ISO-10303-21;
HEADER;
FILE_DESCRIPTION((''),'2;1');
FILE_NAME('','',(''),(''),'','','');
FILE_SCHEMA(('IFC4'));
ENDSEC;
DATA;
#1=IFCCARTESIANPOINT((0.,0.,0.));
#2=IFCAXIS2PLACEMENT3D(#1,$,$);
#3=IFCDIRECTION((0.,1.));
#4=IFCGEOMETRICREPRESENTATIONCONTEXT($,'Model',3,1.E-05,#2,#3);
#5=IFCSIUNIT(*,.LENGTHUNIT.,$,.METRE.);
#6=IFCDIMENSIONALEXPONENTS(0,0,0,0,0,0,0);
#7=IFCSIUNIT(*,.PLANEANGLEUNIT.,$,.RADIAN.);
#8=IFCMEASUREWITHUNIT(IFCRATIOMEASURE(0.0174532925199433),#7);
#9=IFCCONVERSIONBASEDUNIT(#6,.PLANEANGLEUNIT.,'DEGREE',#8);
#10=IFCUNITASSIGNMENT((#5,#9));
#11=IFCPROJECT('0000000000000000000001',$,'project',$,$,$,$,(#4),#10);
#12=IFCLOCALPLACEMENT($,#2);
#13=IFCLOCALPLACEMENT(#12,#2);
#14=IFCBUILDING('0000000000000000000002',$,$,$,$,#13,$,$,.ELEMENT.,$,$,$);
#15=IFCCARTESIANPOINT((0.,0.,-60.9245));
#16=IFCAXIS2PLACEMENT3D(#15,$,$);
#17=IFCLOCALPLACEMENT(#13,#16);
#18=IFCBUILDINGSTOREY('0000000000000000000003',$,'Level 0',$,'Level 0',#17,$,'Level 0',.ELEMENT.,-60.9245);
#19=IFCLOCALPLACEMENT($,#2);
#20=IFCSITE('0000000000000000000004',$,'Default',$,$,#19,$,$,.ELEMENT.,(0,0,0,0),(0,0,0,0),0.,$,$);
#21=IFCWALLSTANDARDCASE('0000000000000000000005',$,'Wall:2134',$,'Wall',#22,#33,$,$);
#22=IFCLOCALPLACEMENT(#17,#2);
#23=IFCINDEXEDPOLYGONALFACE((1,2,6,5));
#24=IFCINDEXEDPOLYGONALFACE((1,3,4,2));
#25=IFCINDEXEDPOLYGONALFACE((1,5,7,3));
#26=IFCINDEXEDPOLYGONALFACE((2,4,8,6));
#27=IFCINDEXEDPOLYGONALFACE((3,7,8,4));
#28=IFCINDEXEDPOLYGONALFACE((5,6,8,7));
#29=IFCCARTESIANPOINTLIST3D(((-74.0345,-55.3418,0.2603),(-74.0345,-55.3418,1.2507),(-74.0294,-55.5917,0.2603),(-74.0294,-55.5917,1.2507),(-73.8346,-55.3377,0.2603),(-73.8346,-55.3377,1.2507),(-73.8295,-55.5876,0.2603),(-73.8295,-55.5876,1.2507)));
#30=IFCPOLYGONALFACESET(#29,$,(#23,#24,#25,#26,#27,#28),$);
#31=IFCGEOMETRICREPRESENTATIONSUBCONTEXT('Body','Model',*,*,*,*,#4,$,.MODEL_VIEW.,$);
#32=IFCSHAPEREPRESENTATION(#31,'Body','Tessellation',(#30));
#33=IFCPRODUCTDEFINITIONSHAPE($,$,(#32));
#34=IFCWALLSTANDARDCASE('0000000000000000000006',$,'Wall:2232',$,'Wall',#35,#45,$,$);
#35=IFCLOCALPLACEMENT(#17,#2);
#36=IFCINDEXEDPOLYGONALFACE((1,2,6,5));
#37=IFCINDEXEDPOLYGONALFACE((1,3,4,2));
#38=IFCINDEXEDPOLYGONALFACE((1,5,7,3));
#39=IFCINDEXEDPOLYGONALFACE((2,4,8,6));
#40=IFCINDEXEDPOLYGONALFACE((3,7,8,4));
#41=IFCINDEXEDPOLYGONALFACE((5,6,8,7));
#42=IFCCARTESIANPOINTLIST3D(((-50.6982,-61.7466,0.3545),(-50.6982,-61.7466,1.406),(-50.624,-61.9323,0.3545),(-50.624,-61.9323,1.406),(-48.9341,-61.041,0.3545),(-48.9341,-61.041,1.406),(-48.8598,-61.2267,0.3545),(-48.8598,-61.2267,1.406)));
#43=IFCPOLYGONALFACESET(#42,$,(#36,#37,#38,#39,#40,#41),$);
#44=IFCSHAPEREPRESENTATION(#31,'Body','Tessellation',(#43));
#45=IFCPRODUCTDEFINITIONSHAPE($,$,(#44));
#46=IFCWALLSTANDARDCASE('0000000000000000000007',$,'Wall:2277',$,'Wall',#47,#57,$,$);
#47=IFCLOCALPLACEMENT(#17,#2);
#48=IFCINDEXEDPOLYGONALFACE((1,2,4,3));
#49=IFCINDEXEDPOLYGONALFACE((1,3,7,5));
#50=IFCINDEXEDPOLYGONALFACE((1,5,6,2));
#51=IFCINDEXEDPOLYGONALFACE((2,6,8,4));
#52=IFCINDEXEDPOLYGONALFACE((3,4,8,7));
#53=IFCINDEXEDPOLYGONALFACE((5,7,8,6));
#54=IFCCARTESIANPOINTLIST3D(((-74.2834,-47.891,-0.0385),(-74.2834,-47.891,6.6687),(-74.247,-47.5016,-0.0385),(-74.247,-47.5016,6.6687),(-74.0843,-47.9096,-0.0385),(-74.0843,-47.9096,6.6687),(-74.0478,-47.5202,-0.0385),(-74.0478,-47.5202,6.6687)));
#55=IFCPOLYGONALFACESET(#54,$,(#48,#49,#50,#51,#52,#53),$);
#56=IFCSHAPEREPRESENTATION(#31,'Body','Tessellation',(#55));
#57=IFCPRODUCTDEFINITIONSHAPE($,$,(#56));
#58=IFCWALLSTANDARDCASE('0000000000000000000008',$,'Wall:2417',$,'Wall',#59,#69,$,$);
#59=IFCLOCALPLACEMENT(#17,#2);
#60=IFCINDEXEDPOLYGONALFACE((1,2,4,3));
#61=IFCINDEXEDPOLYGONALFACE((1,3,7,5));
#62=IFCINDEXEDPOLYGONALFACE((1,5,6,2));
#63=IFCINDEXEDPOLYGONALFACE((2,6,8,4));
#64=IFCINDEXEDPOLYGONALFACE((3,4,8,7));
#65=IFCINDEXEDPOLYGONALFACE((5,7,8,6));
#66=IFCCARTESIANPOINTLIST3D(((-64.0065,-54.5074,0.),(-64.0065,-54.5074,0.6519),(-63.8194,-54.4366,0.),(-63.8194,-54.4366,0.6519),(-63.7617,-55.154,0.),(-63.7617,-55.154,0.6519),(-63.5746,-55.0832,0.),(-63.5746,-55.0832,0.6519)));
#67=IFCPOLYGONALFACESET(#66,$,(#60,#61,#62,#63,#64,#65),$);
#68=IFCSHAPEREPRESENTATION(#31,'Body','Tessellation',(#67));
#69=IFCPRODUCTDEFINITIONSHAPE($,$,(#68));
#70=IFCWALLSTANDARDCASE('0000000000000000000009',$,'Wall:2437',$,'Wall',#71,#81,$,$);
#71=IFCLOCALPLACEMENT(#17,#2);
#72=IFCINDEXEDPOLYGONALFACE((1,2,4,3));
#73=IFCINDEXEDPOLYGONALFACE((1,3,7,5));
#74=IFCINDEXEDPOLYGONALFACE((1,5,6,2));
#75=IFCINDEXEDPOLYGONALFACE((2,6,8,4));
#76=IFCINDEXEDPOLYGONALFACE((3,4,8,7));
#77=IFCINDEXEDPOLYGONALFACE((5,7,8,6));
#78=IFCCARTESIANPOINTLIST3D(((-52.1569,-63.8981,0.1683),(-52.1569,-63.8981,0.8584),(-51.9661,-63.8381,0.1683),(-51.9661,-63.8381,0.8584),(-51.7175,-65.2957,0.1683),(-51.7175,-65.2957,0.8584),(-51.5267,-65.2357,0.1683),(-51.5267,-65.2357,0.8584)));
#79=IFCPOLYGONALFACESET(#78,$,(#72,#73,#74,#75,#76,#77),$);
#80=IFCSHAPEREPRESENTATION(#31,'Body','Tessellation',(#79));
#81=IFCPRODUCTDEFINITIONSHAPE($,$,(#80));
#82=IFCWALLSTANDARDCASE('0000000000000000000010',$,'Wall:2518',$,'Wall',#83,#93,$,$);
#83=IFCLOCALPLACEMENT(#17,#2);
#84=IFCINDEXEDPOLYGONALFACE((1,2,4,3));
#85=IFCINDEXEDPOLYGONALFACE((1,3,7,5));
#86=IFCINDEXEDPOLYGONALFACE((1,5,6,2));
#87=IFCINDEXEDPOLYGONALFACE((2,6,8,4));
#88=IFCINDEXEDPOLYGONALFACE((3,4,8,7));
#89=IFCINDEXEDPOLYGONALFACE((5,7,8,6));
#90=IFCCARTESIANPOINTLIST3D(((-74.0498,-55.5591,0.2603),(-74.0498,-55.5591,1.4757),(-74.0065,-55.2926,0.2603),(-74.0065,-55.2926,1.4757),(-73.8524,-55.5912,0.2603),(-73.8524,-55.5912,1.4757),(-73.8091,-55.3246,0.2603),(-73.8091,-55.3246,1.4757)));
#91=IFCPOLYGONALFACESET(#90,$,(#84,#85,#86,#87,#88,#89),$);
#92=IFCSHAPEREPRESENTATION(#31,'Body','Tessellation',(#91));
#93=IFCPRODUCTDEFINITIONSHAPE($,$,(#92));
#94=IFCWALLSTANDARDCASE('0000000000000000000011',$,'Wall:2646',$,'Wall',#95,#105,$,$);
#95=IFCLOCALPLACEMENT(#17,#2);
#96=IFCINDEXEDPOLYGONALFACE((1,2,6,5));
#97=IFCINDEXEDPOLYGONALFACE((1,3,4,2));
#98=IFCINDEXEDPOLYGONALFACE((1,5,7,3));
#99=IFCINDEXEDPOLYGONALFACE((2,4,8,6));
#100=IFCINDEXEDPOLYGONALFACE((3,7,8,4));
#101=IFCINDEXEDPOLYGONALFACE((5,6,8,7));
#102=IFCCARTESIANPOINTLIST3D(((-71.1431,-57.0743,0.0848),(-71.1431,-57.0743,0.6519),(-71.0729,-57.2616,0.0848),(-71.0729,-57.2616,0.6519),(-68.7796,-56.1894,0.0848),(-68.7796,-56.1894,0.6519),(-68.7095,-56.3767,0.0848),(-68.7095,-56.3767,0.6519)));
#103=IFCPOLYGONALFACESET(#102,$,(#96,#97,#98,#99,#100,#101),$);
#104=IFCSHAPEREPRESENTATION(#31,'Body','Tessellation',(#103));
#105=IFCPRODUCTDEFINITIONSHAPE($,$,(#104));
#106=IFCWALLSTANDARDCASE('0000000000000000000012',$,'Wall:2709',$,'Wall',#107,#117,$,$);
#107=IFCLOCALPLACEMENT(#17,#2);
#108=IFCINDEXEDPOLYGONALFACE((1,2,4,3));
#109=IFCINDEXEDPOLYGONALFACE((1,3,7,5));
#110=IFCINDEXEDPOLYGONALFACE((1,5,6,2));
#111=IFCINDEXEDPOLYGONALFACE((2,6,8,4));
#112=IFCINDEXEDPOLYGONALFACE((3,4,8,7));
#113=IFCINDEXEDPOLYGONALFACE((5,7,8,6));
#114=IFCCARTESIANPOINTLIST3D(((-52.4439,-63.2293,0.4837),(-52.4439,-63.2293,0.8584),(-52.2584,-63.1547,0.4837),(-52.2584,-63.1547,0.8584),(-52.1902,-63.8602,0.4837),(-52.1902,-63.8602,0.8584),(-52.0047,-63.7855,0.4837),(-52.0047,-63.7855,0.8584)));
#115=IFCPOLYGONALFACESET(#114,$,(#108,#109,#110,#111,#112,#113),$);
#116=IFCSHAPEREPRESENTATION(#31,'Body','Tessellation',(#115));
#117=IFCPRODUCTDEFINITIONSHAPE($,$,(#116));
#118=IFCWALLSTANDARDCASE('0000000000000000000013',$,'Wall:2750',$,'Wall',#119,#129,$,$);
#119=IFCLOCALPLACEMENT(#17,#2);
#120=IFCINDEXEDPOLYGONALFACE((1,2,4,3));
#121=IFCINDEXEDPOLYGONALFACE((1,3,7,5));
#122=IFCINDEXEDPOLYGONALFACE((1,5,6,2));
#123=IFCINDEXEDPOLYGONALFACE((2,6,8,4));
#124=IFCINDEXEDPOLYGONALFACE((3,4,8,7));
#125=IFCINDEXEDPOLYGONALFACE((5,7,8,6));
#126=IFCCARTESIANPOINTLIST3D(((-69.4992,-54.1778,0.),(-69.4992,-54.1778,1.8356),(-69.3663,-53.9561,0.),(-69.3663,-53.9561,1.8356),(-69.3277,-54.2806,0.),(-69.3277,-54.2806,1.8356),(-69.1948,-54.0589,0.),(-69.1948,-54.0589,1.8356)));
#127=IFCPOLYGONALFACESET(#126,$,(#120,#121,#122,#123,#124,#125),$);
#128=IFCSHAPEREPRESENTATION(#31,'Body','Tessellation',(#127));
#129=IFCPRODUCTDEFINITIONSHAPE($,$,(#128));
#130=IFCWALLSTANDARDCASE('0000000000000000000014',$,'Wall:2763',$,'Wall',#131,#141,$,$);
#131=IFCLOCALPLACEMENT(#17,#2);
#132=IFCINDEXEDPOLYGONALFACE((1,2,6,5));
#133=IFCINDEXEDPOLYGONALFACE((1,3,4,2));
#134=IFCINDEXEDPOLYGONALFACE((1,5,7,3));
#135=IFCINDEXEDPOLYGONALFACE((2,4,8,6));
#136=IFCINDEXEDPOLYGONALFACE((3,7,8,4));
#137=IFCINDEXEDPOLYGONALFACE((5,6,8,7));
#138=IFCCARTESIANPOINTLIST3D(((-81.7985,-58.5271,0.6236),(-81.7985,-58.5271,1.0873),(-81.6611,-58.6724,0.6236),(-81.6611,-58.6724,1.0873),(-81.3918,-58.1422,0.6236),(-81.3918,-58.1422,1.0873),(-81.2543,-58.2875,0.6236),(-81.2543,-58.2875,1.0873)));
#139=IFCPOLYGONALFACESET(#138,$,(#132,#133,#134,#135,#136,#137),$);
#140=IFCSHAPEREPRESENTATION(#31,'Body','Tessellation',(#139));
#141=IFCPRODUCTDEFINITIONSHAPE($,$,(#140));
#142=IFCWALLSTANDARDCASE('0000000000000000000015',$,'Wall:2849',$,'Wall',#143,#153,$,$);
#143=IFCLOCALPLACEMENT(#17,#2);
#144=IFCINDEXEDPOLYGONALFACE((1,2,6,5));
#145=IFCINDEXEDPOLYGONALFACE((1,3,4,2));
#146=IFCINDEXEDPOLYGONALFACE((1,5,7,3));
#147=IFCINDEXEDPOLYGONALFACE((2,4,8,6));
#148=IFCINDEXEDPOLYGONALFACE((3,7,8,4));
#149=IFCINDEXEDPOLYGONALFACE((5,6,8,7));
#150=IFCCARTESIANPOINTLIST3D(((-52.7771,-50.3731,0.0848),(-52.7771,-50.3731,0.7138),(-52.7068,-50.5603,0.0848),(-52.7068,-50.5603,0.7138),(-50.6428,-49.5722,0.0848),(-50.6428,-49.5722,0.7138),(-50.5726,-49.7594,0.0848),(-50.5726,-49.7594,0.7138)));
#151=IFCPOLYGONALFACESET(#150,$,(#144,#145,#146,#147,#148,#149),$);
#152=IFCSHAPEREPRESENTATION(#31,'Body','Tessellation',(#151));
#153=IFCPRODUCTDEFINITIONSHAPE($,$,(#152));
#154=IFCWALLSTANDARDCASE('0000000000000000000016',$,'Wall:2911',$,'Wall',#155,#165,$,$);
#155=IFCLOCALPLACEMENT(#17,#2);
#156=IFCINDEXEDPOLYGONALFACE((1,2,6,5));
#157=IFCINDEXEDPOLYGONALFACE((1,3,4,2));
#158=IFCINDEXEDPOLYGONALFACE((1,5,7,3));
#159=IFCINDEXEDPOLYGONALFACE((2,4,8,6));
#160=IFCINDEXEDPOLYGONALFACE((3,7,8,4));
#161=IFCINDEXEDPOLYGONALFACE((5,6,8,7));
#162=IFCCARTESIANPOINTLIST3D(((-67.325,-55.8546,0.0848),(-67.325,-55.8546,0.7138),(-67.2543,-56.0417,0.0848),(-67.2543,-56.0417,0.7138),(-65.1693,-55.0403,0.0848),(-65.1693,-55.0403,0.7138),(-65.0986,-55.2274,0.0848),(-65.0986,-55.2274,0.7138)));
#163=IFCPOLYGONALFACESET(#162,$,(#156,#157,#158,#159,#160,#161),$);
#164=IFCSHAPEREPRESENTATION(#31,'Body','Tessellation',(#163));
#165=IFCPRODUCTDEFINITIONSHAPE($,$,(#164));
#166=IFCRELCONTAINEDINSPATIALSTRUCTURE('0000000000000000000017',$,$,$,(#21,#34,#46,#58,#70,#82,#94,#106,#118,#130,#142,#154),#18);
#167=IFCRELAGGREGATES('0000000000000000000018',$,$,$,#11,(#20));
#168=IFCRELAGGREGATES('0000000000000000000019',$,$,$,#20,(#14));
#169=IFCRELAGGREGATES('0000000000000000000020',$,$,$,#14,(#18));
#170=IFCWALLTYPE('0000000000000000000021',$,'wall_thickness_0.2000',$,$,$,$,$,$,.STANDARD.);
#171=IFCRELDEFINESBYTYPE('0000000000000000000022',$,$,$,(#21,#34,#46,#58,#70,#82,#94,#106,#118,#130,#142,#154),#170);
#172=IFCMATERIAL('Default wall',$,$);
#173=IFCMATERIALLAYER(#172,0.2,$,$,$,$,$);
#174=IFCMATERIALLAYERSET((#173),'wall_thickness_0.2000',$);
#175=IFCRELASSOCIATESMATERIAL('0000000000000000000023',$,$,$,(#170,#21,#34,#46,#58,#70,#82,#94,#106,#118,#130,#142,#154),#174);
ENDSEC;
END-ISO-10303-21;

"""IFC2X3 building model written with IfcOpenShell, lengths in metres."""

from ifc_helpers import new_model, entity, si_unit, converted_unit, direction, frame, origin, place, context, subcontext, project, spatial, polyline, outline, extrude, material, layer, layer_set, layer_usage, type_object, element, save


model = new_model("IFC2X3")

# Units and contexts
model_context = context("Model", 3, precision=1e-05, world=origin(), true_north=direction((0.0, 1.0)))
body_context = subcontext(model_context, "Body", "Model", "MODEL_VIEW")
ifc_project = project(units=[si_unit("LENGTHUNIT", "METRE"), converted_unit("PLANEANGLEUNIT", "DEGREE", entity("IfcRatioMeasure", 0.0174532925199433), si_unit("PLANEANGLEUNIT", "RADIAN"), dimensions=[0, 0, 0, 0, 0, 0, 0])], contexts=[model_context])

# Site, building, storey
site_placement = place(None, origin())
site = spatial("IfcSite", under=ifc_project, at=site_placement, Name="Default", CompositionType="ELEMENT", RefLatitude=(0, 0, 0, 0), RefLongitude=(0, 0, 0, 0), RefElevation=0.0)
placement_1 = place(None, origin())
building_placement = place(placement_1, origin())
building = spatial("IfcBuilding", under=site, at=building_placement, CompositionType="ELEMENT")
storey_placement = place(building_placement, frame((0.0, 0.0, -60.9245)))
storey = spatial("IfcBuildingStorey", under=building, at=storey_placement, Name="Level 0", ObjectType="Level 0", LongName="Level 0", CompositionType="ELEMENT", Elevation=-60.9245)

# Walls
ifc_material = material(Name="Default wall")
ifc_layer = layer(ifc_material, 0.2)
ifc_layer_set = layer_set([ifc_layer], Name="wall_thickness_0.2000")
ifc_layer_usage = layer_usage(ifc_layer_set, "AXIS2", "POSITIVE", -0.1)
wall_type = type_object("IfcWallType", Name="wall_thickness_0.2000", PredefinedType="STANDARD", material=ifc_layer_set)
placement_2 = place(building_placement, frame((0.0, 0.0, -60.6642)))
wall_1_placement = place(placement_2, frame((-73.9346, -55.3397, 0.0), z_axis=(0.0, 0.0, 1.0), x_axis=(0.020477, -0.99979, 0.0)))
element("IfcWallStandardCase", 1, at=wall_1_placement, inside=storey, type_object=wall_type, material=ifc_layer_usage, Name="Wall:2134", ObjectType="Wall", context=body_context, shape_type="SweptSolid", body=[
    extrude(outline(polyline([(0.25, -0.1), (0.25, 0.1), (0.0, 0.1), (0.0, -0.1), (0.25, -0.1)])), origin(), (0.0, 0.0, 1.0), 0.9904),
])
placement_3 = place(building_placement, frame((0.0, 0.0, -60.57)))
wall_2_placement = place(placement_3, frame((-50.6611, -61.8395, 0.0), z_axis=(0.0, 0.0, 1.0), x_axis=(0.928483, 0.371375, 0.0)))
element("IfcWallStandardCase", 2, at=wall_2_placement, inside=storey, type_object=wall_type, material=ifc_layer_usage, Name="Wall:2232", ObjectType="Wall", context=body_context, shape_type="SweptSolid", body=[
    extrude(outline(polyline([(1.9, -0.1), (1.9, 0.1), (0.0, 0.1), (0.0, -0.1), (1.9, -0.1)])), origin(), (0.0, 0.0, 1.0), 1.0515),
])
placement_4 = place(building_placement, frame((0.0, 0.0, -60.963)))
wall_3_placement = place(placement_4, frame((-74.1838, -47.9003, 0.0), z_axis=(0.0, 0.0, 1.0), x_axis=(0.093128, 0.995654, 0.0)))
element("IfcWallStandardCase", 3, at=wall_3_placement, inside=storey, type_object=wall_type, material=ifc_layer_usage, Name="Wall:2277", ObjectType="Wall", context=body_context, shape_type="SweptSolid", body=[
    extrude(outline(polyline([(0.3911, -0.1), (0.3911, 0.1), (0.0, 0.1), (0.0, -0.1), (0.3911, -0.1)])), origin(), (0.0, 0.0, 1.0), 6.7072),
])
wall_4_placement = place(storey_placement, frame((-63.6682, -55.1186, 0.0), z_axis=(0.0, 0.0, 1.0), x_axis=(-0.354021, 0.935238, 0.0)))
element("IfcWallStandardCase", 4, at=wall_4_placement, inside=storey, type_object=wall_type, material=ifc_layer_usage, Name="Wall:2417", ObjectType="Wall", context=body_context, shape_type="SweptSolid", body=[
    extrude(outline(polyline([(0.6914, -0.1), (0.6914, 0.1), (0.0, 0.1), (0.0, -0.1), (0.6914, -0.1)])), origin(), (0.0, 0.0, 1.0), 0.6519),
])
placement_5 = place(building_placement, frame((0.0, 0.0, -60.7562)))
wall_5_placement = place(placement_5, frame((-52.0615, -63.8681, 0.0), z_axis=(0.0, 0.0, 1.0), x_axis=(0.299903, -0.95397, 0.0)))
element("IfcWallStandardCase", 5, at=wall_5_placement, inside=storey, type_object=wall_type, material=ifc_layer_usage, Name="Wall:2437", ObjectType="Wall", context=body_context, shape_type="SweptSolid", body=[
    extrude(outline(polyline([(1.465, -0.1), (1.465, 0.1), (0.0, 0.1), (0.0, -0.1), (1.465, -0.1)])), origin(), (0.0, 0.0, 1.0), 0.69),
])
placement_6 = place(building_placement, frame((0.0, 0.0, -60.6642)))
wall_6_placement = place(placement_6, frame((-73.9078, -55.3086, 0.0), z_axis=(0.0, 0.0, 1.0), x_axis=(-0.160329, -0.987064, 0.0)))
element("IfcWallStandardCase", 6, at=wall_6_placement, inside=storey, type_object=wall_type, material=ifc_layer_usage, Name="Wall:2518", ObjectType="Wall", context=body_context, shape_type="SweptSolid", body=[
    extrude(outline(polyline([(0.27, -0.1), (0.27, 0.1), (0.0, 0.1), (0.0, -0.1), (0.27, -0.1)])), origin(), (0.0, 0.0, 1.0), 1.2154),
])
placement_7 = place(building_placement, frame((0.0, 0.0, -60.8397)))
wall_7_placement = place(placement_7, frame((-71.108, -57.1679, 0.0), z_axis=(0.0, 0.0, 1.0), x_axis=(0.936523, 0.350606, 0.0)))
element("IfcWallStandardCase", 7, at=wall_7_placement, inside=storey, type_object=wall_type, material=ifc_layer_usage, Name="Wall:2646", ObjectType="Wall", context=body_context, shape_type="SweptSolid", body=[
    extrude(outline(polyline([(2.5237, -0.1), (2.5237, 0.1), (0.0, 0.1), (0.0, -0.1), (2.5237, -0.1)])), origin(), (0.0, 0.0, 1.0), 0.5671),
])
placement_8 = place(building_placement, frame((0.0, 0.0, -60.4408)))
wall_8_placement = place(placement_8, frame((-52.3512, -63.192, 0.0), z_axis=(0.0, 0.0, 1.0), x_axis=(0.373112, -0.927786, 0.0)))
element("IfcWallStandardCase", 8, at=wall_8_placement, inside=storey, type_object=wall_type, material=ifc_layer_usage, Name="Wall:2709", ObjectType="Wall", context=body_context, shape_type="SweptSolid", body=[
    extrude(outline(polyline([(0.68, -0.1), (0.68, 0.1), (0.0, 0.1), (0.0, -0.1), (0.68, -0.1)])), origin(), (0.0, 0.0, 1.0), 0.3746),
])
wall_9_placement = place(storey_placement, frame((-69.2805, -54.0075, 0.0), z_axis=(0.0, 0.0, 1.0), x_axis=(-0.514142, -0.857705, 0.0)))
element("IfcWallStandardCase", 9, at=wall_9_placement, inside=storey, type_object=wall_type, material=ifc_layer_usage, Name="Wall:2750", ObjectType="Wall", context=body_context, shape_type="SweptSolid", body=[
    extrude(outline(polyline([(0.2585, -0.1), (0.2585, 0.1), (0.0, 0.1), (0.0, -0.1), (0.2585, -0.1)])), origin(), (0.0, 0.0, 1.0), 1.8356),
])
placement_9 = place(building_placement, frame((0.0, 0.0, -60.3009)))
wall_10_placement = place(placement_9, frame((-81.7298, -58.5998, 0.0), z_axis=(0.0, 0.0, 1.0), x_axis=(0.726387, 0.687286, 0.0)))
element("IfcWallStandardCase", 10, at=wall_10_placement, inside=storey, type_object=wall_type, material=ifc_layer_usage, Name="Wall:2763", ObjectType="Wall", context=body_context, shape_type="SweptSolid", body=[
    extrude(outline(polyline([(0.56, -0.1), (0.56, 0.1), (0.0, 0.1), (0.0, -0.1), (0.56, -0.1)])), origin(), (0.0, 0.0, 1.0), 0.4637),
])
placement_10 = place(building_placement, frame((0.0, 0.0, -60.8397)))
wall_11_placement = place(placement_10, frame((-52.7419, -50.4667, 0.0), z_axis=(0.0, 0.0, 1.0), x_axis=(0.936246, 0.351346, 0.0)))
element("IfcWallStandardCase", 11, at=wall_11_placement, inside=storey, type_object=wall_type, material=ifc_layer_usage, Name="Wall:2849", ObjectType="Wall", context=body_context, shape_type="SweptSolid", body=[
    extrude(outline(polyline([(2.2796, -0.1), (2.2796, 0.1), (0.0, 0.1), (0.0, -0.1), (2.2796, -0.1)])), origin(), (0.0, 0.0, 1.0), 0.629),
])
placement_11 = place(building_placement, frame((0.0, 0.0, -60.8397)))
wall_12_placement = place(placement_11, frame((-67.2896, -55.9481, 0.0), z_axis=(0.0, 0.0, 1.0), x_axis=(0.935485, 0.353366, 0.0)))
element("IfcWallStandardCase", 12, at=wall_12_placement, inside=storey, type_object=wall_type, material=ifc_layer_usage, Name="Wall:2911", ObjectType="Wall", context=body_context, shape_type="SweptSolid", body=[
    extrude(outline(polyline([(2.3043, -0.1), (2.3043, 0.1), (0.0, 0.1), (0.0, -0.1), (2.3043, -0.1)])), origin(), (0.0, 0.0, 1.0), 0.629),
])

save(model, "model.ifc")
